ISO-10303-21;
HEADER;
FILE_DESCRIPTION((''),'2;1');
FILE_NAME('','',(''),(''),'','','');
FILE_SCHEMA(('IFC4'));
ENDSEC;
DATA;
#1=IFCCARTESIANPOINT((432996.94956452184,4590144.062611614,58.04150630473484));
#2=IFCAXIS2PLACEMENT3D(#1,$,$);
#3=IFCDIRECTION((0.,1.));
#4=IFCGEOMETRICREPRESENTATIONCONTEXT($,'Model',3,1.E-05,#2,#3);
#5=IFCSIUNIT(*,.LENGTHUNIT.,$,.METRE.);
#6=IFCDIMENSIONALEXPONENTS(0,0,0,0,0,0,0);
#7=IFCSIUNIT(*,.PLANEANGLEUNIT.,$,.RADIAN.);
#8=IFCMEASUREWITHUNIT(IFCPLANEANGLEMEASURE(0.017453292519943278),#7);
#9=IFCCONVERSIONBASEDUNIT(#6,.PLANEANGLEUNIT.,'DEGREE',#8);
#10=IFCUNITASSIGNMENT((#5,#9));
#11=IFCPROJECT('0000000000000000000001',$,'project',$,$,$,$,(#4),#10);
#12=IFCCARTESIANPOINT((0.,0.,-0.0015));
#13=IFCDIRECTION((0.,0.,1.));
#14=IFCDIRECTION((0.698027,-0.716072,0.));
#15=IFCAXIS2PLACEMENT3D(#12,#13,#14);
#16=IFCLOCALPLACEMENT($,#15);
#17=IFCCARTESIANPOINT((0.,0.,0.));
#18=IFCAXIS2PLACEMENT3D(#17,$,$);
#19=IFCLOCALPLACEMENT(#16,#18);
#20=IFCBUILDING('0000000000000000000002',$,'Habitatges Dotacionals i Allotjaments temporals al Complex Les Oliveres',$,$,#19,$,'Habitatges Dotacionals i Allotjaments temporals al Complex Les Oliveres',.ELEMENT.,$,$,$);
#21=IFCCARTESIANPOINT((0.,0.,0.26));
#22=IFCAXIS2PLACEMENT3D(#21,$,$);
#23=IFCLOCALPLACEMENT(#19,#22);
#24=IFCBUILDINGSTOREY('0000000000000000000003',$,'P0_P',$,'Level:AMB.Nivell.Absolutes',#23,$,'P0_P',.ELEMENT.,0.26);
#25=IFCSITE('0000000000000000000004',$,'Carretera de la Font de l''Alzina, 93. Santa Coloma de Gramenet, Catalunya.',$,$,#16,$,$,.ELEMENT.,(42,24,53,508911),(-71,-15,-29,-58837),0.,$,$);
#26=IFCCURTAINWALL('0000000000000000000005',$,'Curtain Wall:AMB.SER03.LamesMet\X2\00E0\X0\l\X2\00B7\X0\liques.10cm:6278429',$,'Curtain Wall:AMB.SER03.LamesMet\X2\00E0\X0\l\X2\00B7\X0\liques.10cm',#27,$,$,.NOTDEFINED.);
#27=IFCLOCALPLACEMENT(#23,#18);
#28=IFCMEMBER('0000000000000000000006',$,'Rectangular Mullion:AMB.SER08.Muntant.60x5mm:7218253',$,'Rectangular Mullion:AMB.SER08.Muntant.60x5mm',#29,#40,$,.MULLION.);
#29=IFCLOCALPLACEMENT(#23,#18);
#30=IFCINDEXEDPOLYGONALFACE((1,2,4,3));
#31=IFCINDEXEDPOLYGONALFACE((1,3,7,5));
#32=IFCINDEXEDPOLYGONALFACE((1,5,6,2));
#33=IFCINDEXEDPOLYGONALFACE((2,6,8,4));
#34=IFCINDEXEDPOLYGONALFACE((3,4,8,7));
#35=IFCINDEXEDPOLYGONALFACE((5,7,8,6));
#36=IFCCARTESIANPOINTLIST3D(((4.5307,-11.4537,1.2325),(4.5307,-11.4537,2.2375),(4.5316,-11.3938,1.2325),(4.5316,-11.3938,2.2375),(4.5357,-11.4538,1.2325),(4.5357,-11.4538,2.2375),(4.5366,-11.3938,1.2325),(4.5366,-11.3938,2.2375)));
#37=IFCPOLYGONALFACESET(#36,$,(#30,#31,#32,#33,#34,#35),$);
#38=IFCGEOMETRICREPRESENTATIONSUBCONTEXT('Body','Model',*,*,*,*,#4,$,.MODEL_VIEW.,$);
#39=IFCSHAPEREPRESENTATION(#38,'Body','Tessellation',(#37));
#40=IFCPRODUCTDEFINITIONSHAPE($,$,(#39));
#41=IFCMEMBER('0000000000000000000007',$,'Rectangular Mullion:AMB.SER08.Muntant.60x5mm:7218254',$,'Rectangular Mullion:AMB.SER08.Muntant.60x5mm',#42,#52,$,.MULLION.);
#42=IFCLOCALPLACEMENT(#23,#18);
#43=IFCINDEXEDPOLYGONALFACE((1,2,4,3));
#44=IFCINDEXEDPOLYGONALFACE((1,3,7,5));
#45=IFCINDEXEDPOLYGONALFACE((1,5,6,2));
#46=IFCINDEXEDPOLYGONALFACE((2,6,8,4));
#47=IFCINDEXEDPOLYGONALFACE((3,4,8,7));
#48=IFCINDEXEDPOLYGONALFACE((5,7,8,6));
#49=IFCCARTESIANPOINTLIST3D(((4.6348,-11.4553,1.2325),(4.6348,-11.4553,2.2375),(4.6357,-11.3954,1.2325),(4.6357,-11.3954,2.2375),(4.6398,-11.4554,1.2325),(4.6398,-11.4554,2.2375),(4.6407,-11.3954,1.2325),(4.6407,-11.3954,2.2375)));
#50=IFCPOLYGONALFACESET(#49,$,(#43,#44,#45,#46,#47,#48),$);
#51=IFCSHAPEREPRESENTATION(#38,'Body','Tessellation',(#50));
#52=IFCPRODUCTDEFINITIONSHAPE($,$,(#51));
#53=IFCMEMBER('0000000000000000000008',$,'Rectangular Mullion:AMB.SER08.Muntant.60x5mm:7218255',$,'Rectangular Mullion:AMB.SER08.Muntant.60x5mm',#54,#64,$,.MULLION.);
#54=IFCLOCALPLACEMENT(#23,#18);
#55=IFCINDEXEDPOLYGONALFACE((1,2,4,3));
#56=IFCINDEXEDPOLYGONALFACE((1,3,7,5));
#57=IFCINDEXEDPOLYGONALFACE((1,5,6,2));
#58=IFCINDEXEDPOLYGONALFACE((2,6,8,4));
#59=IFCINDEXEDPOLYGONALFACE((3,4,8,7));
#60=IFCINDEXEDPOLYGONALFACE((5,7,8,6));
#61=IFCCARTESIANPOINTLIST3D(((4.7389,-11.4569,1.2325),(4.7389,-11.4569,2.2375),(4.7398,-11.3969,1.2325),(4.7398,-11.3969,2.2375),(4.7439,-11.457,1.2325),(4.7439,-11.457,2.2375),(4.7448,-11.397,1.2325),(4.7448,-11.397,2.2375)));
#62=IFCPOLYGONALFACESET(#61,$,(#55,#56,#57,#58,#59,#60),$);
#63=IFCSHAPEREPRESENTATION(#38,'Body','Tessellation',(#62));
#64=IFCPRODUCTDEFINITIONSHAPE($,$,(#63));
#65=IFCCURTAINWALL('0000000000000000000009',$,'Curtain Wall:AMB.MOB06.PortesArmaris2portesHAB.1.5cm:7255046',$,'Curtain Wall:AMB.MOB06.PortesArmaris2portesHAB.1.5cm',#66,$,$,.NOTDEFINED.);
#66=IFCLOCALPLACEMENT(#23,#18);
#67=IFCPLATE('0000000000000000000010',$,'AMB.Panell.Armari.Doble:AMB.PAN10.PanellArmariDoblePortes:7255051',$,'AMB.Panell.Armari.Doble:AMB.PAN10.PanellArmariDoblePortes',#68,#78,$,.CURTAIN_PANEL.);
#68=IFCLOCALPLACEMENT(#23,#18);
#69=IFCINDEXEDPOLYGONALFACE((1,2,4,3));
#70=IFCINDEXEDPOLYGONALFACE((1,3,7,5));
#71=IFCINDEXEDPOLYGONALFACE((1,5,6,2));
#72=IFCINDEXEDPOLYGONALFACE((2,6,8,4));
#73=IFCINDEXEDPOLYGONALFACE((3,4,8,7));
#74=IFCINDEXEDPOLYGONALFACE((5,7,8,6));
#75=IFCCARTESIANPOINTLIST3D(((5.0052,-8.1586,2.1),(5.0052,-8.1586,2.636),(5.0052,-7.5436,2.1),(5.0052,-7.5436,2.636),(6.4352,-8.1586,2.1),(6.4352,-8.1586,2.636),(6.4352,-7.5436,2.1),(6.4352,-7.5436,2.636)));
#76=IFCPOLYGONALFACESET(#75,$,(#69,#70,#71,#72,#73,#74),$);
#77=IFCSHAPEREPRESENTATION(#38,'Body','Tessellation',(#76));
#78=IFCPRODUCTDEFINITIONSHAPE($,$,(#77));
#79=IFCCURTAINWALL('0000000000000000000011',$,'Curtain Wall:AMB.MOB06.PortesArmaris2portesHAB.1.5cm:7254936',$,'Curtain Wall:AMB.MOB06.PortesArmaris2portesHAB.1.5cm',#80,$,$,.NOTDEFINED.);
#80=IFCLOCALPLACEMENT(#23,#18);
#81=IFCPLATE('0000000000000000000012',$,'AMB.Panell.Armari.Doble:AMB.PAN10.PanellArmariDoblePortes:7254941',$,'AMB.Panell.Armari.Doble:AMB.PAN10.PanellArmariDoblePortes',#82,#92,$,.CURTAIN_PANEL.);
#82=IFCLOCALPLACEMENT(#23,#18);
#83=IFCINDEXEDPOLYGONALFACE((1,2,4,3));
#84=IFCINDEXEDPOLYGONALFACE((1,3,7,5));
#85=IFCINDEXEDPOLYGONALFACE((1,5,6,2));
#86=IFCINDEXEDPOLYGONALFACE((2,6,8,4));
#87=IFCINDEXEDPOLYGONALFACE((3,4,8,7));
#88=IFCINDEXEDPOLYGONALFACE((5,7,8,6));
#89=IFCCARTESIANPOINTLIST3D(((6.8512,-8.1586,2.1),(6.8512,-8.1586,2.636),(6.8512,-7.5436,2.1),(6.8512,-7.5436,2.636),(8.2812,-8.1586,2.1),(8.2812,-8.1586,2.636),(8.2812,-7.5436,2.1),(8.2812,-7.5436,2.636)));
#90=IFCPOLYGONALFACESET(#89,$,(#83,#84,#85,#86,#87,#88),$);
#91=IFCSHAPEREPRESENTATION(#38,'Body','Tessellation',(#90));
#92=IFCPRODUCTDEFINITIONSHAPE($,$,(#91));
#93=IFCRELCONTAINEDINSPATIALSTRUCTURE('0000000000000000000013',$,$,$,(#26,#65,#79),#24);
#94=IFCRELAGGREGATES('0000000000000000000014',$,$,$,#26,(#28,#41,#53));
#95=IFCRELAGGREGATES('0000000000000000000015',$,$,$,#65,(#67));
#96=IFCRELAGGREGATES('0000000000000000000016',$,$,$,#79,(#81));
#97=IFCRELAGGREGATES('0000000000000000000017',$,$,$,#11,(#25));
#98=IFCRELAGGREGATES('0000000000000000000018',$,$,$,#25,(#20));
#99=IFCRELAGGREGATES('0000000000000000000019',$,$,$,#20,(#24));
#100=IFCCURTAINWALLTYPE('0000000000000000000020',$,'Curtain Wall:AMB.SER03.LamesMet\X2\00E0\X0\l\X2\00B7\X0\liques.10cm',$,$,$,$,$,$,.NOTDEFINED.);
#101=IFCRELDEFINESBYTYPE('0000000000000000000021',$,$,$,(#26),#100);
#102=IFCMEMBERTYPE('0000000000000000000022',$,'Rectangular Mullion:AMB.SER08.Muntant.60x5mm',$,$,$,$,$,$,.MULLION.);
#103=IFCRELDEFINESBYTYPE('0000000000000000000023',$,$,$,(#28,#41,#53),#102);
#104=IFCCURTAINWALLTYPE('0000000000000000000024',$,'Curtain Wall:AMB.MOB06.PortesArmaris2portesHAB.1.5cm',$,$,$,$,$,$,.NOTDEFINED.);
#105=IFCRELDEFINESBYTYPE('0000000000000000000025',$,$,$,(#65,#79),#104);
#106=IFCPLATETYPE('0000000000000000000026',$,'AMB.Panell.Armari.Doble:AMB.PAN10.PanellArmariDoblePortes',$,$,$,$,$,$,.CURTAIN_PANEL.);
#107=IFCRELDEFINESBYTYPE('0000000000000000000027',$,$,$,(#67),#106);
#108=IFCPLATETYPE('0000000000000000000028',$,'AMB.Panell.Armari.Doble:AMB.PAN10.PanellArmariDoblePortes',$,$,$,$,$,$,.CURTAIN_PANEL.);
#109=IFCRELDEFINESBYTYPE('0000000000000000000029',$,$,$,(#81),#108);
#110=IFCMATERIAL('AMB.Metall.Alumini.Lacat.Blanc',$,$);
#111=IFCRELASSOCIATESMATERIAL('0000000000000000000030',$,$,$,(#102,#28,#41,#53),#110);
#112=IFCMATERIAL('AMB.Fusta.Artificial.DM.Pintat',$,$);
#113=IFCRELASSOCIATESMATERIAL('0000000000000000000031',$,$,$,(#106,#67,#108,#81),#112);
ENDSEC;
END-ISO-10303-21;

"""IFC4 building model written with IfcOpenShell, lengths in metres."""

from ifc_helpers import new_model, entity, si_unit, converted_unit, direction, frame, origin, place, context, subcontext, project, spatial, indexed_curve, outline, extrude, source, transform, mapped, material, type_object, type_shapes, element, aggregate, save


model = new_model("IFC4")

# Units and contexts
model_context = context("Model", 3, precision=1e-05, world=frame((432996.94956452184, 4590144.062611614, 58.04150630473484)), true_north=direction((0.0, 1.0)))
body_context = subcontext(model_context, "Body", "Model", "MODEL_VIEW")
ifc_project = project(units=[si_unit("LENGTHUNIT", "METRE"), converted_unit("PLANEANGLEUNIT", "DEGREE", entity("IfcPlaneAngleMeasure", 0.017453292519943278), si_unit("PLANEANGLEUNIT", "RADIAN"), dimensions=[0, 0, 0, 0, 0, 0, 0])], contexts=[model_context])

# Site, building, storey
site_placement = place(None, frame((0.0, 0.0, -0.0015), z_axis=(0.0, 0.0, 1.0), x_axis=(0.698027, -0.716072, 0.0)))
site = spatial("IfcSite", under=ifc_project, at=site_placement, Name="Carretera de la Font de l'Alzina, 93. Santa Coloma de Gramenet, Catalunya.", CompositionType="ELEMENT", RefLatitude=(42, 24, 53, 508911), RefLongitude=(-71, -15, -29, -58837), RefElevation=0.0)
building_placement = place(site_placement, origin())
building = spatial("IfcBuilding", under=site, at=building_placement, Name="Habitatges Dotacionals i Allotjaments temporals al Complex Les Oliveres", LongName="Habitatges Dotacionals i Allotjaments temporals al Complex Les Oliveres", CompositionType="ELEMENT")
storey_placement = place(building_placement, frame((0.0, 0.0, 0.26)))
storey = spatial("IfcBuildingStorey", under=building, at=storey_placement, Name="P0_P", ObjectType="Level:AMB.Nivell.Absolutes", LongName="P0_P", CompositionType="ELEMENT", Elevation=0.26)

# Curtain wall, members
curtain_wall_type_1 = type_object("IfcCurtainWallType", Name="Curtain Wall:AMB.SER03.LamesMetàl·liques.10cm", PredefinedType="NOTDEFINED")
curtain_wall_1_placement = place(storey_placement, frame((0.0, 0.0, -0.26)))
curtain_wall_1 = element("IfcCurtainWall", 1, at=curtain_wall_1_placement, inside=storey, type_object=curtain_wall_type_1, Name="Curtain Wall:AMB.SER03.LamesMetàl·liques.10cm:6278429", ObjectType="Curtain Wall:AMB.SER03.LamesMetàl·liques.10cm", PredefinedType="NOTDEFINED")
ifc_material_1 = material(Name="AMB.Metall.Alumini.Lacat.Blanc")
member_type_1 = type_object("IfcMemberType", Name="Rectangular Mullion:AMB.SER08.Muntant.60x5mm", PredefinedType="MULLION", material=ifc_material_1)
shared_shape_1 = source(origin(), body_context, "Body", "SweptSolid", [
    extrude(outline(indexed_curve([(-0.0025, -0.03), (0.0025, -0.03), (0.0025, 0.03), (-0.0025, 0.03), (-0.0025, -0.03)], self_intersect=False)), frame((0.0, 0.03, -1.005), z_axis=(0.0, 0.0, 1.0), x_axis=(-1.0, 0.0, 0.0)), (0.0, 0.0, 1.0), 1.005),
])
type_shapes(member_type_1, [shared_shape_1])
member_1_placement = place(curtain_wall_1_placement, frame((4.5332, -11.4538, 1.4925), z_axis=(0.0, 0.0, -1.0), x_axis=(-0.999883, 0.015319, 0.0)))
member_1 = element("IfcMember", 2, at=member_1_placement, type_object=member_type_1, material=ifc_material_1, Name="Rectangular Mullion:AMB.SER08.Muntant.60x5mm:7218253", ObjectType="Rectangular Mullion:AMB.SER08.Muntant.60x5mm", PredefinedType="MULLION", context=body_context, shape_type="MappedRepresentation", body=[
    mapped(shared_shape_1, transform((0.0, 0.0, 0.0), scale=1.0)),
])
member_2_placement = place(curtain_wall_1_placement, frame((4.6373, -11.4554, 1.4925), z_axis=(0.0, 0.0, -1.0), x_axis=(-0.999883, 0.015319, 0.0)))
member_2 = element("IfcMember", 3, at=member_2_placement, type_object=member_type_1, material=ifc_material_1, Name="Rectangular Mullion:AMB.SER08.Muntant.60x5mm:7218254", ObjectType="Rectangular Mullion:AMB.SER08.Muntant.60x5mm", PredefinedType="MULLION", context=body_context, shape_type="MappedRepresentation", body=[
    mapped(shared_shape_1, transform((0.0, 0.0, 0.0), scale=1.0)),
])
member_3_placement = place(curtain_wall_1_placement, frame((4.7414, -11.457, 1.4925), z_axis=(0.0, 0.0, -1.0), x_axis=(-0.999883, 0.015319, 0.0)))
member_3 = element("IfcMember", 4, at=member_3_placement, type_object=member_type_1, material=ifc_material_1, Name="Rectangular Mullion:AMB.SER08.Muntant.60x5mm:7218255", ObjectType="Rectangular Mullion:AMB.SER08.Muntant.60x5mm", PredefinedType="MULLION", context=body_context, shape_type="MappedRepresentation", body=[
    mapped(shared_shape_1, transform((0.0, 0.0, 0.0), scale=1.0)),
])
aggregate(curtain_wall_1, [member_1, member_2, member_3])

# Curtain walls, plates
curtain_wall_type_2 = type_object("IfcCurtainWallType", Name="Curtain Wall:AMB.MOB06.PortesArmaris2portesHAB.1.5cm", PredefinedType="NOTDEFINED")
curtain_wall_2_placement = place(storey_placement, frame((0.0, 0.0, -0.26)))
curtain_wall_2 = element("IfcCurtainWall", 5, at=curtain_wall_2_placement, inside=storey, type_object=curtain_wall_type_2, Name="Curtain Wall:AMB.MOB06.PortesArmaris2portesHAB.1.5cm:7255046", ObjectType="Curtain Wall:AMB.MOB06.PortesArmaris2portesHAB.1.5cm", PredefinedType="NOTDEFINED")
ifc_material_2 = material(Name="AMB.Fusta.Artificial.DM.Pintat")
plate_type_1 = type_object("IfcPlateType", Name="AMB.Panell.Armari.Doble:AMB.PAN10.PanellArmariDoblePortes", PredefinedType="CURTAIN_PANEL", material=ifc_material_2)
shared_shape_2 = source(origin(), body_context, "Body", "SweptSolid", [
    extrude(outline(indexed_curve([(-0.715, -0.3075), (0.715, -0.3075), (0.715, 0.3075), (-0.715, 0.3075), (-0.715, -0.3075)], self_intersect=False)), frame((0.0, -0.3075, 0.0), z_axis=(0.0, 0.0, 1.0), x_axis=(-1.0, 0.0, 0.0)), (0.0, 0.0, 1.0), 0.536),
])
type_shapes(plate_type_1, [shared_shape_2])
plate_1_placement = place(curtain_wall_2_placement, frame((5.7202, -8.1586, 2.36), z_axis=(0.0, 0.0, 1.0), x_axis=(-1.0, 0.0, 0.0)))
plate_1 = element("IfcPlate", 6, at=plate_1_placement, type_object=plate_type_1, material=ifc_material_2, Name="AMB.Panell.Armari.Doble:AMB.PAN10.PanellArmariDoblePortes:7255051", ObjectType="AMB.Panell.Armari.Doble:AMB.PAN10.PanellArmariDoblePortes", PredefinedType="CURTAIN_PANEL", context=body_context, shape_type="MappedRepresentation", body=[
    mapped(shared_shape_2, transform((0.0, 0.0, 0.0), scale=1.0)),
])
aggregate(curtain_wall_2, [plate_1])
curtain_wall_3_placement = place(storey_placement, frame((0.0, 0.0, -0.26)))
curtain_wall_3 = element("IfcCurtainWall", 7, at=curtain_wall_3_placement, inside=storey, type_object=curtain_wall_type_2, Name="Curtain Wall:AMB.MOB06.PortesArmaris2portesHAB.1.5cm:7254936", ObjectType="Curtain Wall:AMB.MOB06.PortesArmaris2portesHAB.1.5cm", PredefinedType="NOTDEFINED")
plate_type_2 = type_object("IfcPlateType", Name="AMB.Panell.Armari.Doble:AMB.PAN10.PanellArmariDoblePortes", PredefinedType="CURTAIN_PANEL", material=ifc_material_2)
shared_shape_3 = source(origin(), body_context, "Body", "SweptSolid", [
    extrude(outline(indexed_curve([(-0.3075, -0.715), (0.3075, -0.715), (0.3075, 0.715), (-0.3075, 0.715), (-0.3075, -0.715)], self_intersect=False)), frame((0.0, 0.3075, 0.0), z_axis=(0.0, 0.0, 1.0), x_axis=(0.0, 1.0, 0.0)), (0.0, 0.0, 1.0), 0.536),
])
type_shapes(plate_type_2, [shared_shape_3])
plate_2_placement = place(curtain_wall_3_placement, frame((7.5662, -8.1586, 2.36)))
plate_2 = element("IfcPlate", 8, at=plate_2_placement, type_object=plate_type_2, material=ifc_material_2, Name="AMB.Panell.Armari.Doble:AMB.PAN10.PanellArmariDoblePortes:7254941", ObjectType="AMB.Panell.Armari.Doble:AMB.PAN10.PanellArmariDoblePortes", PredefinedType="CURTAIN_PANEL", context=body_context, shape_type="MappedRepresentation", body=[
    mapped(shared_shape_3, transform((0.0, 0.0, 0.0), scale=1.0)),
])
aggregate(curtain_wall_3, [plate_2])

save(model, "model.ifc")
